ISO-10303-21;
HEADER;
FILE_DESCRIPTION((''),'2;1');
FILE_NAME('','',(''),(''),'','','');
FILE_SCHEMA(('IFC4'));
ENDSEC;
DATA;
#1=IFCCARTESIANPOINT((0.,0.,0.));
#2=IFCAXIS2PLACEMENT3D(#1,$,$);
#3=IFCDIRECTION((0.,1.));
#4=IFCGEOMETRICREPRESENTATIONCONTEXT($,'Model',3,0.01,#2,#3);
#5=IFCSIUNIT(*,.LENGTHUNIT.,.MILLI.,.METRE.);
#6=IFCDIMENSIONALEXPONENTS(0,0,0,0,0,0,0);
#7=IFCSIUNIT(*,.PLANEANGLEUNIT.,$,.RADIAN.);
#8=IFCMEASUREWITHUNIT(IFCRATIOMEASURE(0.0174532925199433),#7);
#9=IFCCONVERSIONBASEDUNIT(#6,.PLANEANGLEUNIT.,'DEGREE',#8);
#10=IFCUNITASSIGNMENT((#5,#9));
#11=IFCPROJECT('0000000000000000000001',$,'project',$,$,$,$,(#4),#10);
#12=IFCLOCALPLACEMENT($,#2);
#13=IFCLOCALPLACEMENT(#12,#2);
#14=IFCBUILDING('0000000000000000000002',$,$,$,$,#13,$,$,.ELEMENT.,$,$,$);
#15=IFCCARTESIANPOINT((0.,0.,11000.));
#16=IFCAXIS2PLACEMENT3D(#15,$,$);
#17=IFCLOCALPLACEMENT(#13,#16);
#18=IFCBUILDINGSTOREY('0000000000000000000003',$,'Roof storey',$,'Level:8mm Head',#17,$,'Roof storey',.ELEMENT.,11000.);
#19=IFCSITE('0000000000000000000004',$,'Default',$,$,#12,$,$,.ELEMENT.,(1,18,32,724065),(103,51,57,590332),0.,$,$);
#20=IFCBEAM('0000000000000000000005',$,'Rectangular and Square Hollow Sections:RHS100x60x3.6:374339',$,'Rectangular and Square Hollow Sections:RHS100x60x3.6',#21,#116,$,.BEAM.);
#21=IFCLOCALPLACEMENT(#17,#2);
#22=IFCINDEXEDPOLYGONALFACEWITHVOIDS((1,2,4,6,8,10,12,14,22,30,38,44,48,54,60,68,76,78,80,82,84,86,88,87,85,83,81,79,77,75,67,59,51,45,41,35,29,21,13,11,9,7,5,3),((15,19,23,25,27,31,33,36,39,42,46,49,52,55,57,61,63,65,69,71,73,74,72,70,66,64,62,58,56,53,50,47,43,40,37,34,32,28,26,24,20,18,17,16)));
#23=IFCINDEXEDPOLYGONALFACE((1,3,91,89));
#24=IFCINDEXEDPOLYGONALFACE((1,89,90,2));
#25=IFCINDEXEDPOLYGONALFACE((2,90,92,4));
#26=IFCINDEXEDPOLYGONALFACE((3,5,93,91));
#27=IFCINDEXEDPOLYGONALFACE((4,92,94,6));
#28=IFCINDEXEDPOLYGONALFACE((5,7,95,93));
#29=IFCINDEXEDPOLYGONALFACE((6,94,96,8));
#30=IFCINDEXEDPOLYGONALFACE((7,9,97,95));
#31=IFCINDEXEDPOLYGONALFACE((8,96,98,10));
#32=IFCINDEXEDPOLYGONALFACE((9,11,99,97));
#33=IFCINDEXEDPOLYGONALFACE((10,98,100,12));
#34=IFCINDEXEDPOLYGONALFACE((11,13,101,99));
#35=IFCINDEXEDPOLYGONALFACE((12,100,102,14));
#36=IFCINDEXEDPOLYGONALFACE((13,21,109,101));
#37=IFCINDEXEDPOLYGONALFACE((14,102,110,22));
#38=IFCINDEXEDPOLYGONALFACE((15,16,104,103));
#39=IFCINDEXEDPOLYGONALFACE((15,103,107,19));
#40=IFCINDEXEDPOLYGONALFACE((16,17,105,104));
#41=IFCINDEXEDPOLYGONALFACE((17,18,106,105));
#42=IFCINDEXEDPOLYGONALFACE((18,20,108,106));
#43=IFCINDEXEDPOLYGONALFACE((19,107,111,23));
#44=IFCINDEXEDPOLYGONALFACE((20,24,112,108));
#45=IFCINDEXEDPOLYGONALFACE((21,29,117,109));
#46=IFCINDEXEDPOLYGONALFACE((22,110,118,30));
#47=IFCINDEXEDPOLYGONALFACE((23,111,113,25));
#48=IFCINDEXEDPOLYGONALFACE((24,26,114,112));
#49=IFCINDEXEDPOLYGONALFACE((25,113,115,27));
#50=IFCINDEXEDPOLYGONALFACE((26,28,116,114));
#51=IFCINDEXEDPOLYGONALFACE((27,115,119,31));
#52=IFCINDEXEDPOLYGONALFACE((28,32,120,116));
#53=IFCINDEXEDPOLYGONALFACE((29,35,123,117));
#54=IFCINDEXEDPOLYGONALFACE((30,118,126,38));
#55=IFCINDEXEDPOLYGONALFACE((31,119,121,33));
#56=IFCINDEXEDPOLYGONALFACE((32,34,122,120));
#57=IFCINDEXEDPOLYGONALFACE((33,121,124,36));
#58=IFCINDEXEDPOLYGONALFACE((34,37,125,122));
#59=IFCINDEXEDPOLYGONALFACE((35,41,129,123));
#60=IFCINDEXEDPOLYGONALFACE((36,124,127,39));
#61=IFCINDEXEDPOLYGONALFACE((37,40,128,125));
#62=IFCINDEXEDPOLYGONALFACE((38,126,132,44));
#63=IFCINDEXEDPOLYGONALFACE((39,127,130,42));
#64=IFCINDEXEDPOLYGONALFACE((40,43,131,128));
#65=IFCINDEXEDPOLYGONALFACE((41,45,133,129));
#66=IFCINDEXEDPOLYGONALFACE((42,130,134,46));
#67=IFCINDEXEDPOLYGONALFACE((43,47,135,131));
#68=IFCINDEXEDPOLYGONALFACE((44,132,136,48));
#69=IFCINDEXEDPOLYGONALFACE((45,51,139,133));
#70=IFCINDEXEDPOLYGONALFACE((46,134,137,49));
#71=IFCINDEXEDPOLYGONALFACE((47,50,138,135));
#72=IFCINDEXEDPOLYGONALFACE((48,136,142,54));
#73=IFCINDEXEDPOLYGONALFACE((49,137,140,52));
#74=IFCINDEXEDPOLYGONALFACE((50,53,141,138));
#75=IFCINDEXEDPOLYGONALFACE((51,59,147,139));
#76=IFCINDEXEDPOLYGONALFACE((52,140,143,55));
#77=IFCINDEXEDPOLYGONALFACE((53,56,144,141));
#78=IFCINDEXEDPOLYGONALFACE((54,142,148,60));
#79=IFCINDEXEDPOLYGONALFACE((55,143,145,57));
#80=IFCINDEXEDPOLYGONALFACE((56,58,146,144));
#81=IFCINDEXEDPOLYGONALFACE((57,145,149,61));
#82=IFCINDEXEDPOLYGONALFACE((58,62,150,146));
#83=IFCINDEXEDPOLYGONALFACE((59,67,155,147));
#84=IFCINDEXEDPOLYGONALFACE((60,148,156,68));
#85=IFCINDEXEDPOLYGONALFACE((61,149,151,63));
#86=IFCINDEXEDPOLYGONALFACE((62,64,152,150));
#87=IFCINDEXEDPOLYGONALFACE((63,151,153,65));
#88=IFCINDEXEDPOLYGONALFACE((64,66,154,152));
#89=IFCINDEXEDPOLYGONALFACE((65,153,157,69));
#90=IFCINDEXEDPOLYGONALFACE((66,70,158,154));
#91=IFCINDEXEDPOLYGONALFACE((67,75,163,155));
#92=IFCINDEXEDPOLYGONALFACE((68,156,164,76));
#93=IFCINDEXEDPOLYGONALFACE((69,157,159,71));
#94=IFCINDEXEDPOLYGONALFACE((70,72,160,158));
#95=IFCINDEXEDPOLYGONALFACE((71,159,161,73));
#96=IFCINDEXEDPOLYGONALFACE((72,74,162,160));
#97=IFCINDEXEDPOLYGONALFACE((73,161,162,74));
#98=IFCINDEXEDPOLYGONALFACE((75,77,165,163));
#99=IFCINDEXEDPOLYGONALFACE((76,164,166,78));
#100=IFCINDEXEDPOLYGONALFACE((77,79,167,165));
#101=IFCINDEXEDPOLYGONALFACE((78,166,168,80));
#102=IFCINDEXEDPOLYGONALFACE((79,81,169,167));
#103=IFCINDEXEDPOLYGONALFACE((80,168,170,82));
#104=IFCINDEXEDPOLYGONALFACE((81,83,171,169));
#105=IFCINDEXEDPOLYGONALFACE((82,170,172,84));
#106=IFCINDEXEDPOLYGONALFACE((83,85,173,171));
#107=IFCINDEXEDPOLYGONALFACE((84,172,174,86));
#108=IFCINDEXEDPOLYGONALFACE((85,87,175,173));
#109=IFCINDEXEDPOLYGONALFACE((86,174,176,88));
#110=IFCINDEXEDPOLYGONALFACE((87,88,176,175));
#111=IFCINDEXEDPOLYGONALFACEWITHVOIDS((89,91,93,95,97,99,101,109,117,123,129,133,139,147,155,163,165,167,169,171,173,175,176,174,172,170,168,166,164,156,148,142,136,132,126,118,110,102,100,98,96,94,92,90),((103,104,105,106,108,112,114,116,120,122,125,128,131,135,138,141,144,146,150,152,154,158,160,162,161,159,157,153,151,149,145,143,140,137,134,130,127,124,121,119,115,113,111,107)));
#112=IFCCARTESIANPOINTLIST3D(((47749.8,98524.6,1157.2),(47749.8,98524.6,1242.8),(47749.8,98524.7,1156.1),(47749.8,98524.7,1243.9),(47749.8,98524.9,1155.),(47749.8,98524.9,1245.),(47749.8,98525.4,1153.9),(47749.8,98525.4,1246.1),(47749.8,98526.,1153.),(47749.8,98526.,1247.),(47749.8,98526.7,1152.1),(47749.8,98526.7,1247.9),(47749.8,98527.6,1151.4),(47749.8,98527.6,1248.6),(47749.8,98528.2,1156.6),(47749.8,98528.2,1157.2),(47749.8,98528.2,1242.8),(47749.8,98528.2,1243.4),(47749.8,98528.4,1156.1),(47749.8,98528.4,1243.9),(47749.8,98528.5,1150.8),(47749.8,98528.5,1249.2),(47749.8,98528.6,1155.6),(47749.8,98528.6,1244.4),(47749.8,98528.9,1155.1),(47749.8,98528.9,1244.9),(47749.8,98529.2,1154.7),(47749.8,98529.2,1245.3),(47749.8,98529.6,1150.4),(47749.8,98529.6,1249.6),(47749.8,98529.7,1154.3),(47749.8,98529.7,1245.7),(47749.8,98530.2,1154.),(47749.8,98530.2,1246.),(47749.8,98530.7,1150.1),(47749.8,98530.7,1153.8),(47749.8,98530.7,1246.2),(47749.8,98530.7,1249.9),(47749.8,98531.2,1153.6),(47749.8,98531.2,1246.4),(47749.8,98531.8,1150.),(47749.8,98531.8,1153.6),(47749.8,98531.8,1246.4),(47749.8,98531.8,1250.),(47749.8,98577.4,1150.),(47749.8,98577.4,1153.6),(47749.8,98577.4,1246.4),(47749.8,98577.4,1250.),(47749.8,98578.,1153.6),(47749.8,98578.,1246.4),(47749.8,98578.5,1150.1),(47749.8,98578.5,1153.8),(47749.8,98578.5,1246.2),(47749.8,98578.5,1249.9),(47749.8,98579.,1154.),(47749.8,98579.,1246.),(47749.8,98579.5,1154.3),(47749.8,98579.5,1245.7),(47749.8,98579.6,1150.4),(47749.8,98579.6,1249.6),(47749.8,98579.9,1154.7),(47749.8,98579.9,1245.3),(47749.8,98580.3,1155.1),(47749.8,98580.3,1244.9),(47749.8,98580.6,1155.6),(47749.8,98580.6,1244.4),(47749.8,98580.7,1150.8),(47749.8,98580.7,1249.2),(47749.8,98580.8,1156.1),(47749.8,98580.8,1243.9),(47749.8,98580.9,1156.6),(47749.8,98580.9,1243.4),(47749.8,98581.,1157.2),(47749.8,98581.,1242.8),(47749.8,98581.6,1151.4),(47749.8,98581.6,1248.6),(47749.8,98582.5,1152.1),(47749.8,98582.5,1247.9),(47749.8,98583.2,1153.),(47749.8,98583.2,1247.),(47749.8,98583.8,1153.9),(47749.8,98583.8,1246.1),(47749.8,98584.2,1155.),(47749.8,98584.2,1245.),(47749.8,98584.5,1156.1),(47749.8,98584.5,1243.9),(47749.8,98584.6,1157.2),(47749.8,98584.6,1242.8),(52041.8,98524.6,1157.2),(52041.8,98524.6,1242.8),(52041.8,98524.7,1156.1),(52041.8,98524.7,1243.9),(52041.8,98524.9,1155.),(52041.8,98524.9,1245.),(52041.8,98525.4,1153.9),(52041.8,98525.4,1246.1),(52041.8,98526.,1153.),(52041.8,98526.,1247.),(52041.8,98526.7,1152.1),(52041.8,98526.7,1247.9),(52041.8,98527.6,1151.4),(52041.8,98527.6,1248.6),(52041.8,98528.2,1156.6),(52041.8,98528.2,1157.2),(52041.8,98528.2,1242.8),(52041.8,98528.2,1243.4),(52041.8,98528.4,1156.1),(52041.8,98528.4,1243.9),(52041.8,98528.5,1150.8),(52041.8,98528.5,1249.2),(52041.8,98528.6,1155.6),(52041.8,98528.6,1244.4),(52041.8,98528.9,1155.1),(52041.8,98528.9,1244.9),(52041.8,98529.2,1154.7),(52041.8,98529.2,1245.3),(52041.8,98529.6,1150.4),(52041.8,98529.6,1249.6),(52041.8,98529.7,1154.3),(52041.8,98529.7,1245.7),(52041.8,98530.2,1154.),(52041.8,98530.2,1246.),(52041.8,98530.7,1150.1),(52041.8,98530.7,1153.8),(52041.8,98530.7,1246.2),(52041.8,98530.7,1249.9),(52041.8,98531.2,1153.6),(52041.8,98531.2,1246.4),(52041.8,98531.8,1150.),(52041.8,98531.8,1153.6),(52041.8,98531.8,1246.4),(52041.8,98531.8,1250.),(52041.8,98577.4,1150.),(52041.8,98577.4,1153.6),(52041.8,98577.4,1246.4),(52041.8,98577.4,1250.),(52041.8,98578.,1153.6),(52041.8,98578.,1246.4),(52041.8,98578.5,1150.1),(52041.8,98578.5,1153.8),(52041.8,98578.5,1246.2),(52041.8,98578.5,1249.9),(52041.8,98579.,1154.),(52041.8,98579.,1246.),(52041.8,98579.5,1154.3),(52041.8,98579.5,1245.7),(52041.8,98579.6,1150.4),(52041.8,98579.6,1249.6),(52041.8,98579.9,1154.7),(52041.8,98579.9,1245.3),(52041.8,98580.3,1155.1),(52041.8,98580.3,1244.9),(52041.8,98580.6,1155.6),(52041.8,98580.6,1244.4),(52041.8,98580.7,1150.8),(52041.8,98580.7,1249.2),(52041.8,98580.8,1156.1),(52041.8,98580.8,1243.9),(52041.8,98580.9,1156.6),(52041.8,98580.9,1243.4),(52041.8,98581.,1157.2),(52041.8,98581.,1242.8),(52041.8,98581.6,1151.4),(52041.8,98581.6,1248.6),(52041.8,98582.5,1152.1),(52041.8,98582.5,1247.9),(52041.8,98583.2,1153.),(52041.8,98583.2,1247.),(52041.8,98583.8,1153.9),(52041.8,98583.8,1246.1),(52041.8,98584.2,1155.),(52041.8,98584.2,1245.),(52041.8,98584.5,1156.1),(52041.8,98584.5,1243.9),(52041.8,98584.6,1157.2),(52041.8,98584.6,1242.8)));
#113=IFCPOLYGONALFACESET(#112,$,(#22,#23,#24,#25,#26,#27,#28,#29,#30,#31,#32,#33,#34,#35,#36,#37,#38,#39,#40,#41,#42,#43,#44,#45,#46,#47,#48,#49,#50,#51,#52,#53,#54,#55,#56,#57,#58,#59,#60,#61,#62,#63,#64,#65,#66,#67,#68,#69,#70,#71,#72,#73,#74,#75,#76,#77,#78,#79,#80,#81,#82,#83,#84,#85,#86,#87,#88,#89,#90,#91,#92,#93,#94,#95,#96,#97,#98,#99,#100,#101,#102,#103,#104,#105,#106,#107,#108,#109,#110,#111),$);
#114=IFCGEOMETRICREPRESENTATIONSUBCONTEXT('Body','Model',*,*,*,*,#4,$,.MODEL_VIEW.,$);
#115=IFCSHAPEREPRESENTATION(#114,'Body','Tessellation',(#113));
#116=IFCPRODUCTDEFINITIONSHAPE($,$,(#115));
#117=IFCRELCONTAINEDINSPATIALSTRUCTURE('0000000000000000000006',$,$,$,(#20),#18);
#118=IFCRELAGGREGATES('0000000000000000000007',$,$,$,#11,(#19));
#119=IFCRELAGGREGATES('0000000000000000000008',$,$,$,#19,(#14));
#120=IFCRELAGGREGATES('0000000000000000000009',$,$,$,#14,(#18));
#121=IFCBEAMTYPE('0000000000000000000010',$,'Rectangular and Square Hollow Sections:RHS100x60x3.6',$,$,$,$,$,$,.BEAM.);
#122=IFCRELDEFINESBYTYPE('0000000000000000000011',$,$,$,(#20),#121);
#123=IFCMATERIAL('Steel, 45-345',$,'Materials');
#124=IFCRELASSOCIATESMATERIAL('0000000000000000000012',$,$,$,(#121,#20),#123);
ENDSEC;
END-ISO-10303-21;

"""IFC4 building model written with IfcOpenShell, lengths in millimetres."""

from ifc_helpers import new_model, entity, si_unit, converted_unit, direction, frame, origin, place, context, subcontext, project, spatial, indexed_curve, outline, extrude, source, transform, mapped, material, type_object, type_shapes, element, save


model = new_model("IFC4")

# Units and contexts
model_context = context("Model", 3, precision=0.01, world=origin(), true_north=direction((0.0, 1.0)))
body_context = subcontext(model_context, "Body", "Model", "MODEL_VIEW")
ifc_project = project(units=[si_unit("LENGTHUNIT", "METRE", prefix="MILLI"), converted_unit("PLANEANGLEUNIT", "DEGREE", entity("IfcRatioMeasure", 0.0174532925199433), si_unit("PLANEANGLEUNIT", "RADIAN"), dimensions=[0, 0, 0, 0, 0, 0, 0])], contexts=[model_context])

# Site, building, storey
site_placement = place(None, origin())
site = spatial("IfcSite", under=ifc_project, at=site_placement, Name="Default", CompositionType="ELEMENT", RefLatitude=(1, 18, 32, 724065), RefLongitude=(103, 51, 57, 590332), RefElevation=0.0)
building_placement = place(site_placement, origin())
building = spatial("IfcBuilding", under=site, at=building_placement, CompositionType="ELEMENT")
storey_placement = place(building_placement, frame((0.0, 0.0, 11000.0)))
storey = spatial("IfcBuildingStorey", under=building, at=storey_placement, Name="Roof storey", ObjectType="Level:8mm Head", LongName="Roof storey", CompositionType="ELEMENT", Elevation=11000.0)

# Shared definitions
ifc_material = material(Name="Steel, 45-345", Category="Materials")

# Beam
beam_type_1 = type_object("IfcBeamType", Name="Rectangular and Square Hollow Sections:RHS100x60x3.6", PredefinedType="BEAM", material=ifc_material)
shared_shape_1 = source(origin(), body_context, "Body", "SweptSolid", [
    extrude(outline(indexed_curve([(-30.0, -42.8), (-29.9, -43.9), (-29.6, -45.0), (-29.2, -46.1), (-28.6, -47.0), (-27.9, -47.9), (-27.0, -48.6), (-26.1, -49.2), (-25.0, -49.6), (-23.9, -49.9), (-22.8, -50.0), (22.8, -50.0), (23.9, -49.9), (25.0, -49.6), (26.1, -49.2), (27.0, -48.6), (27.9, -47.9), (28.6, -47.0), (29.2, -46.1), (29.6, -45.0), (29.9, -43.9), (30.0, -42.8), (30.0, 42.8), (29.9, 43.9), (29.6, 45.0), (29.2, 46.1), (28.6, 47.0), (27.9, 47.9), (27.0, 48.6), (26.1, 49.2), (25.0, 49.6), (23.9, 49.9), (22.8, 50.0), (-22.8, 50.0), (-23.9, 49.9), (-25.0, 49.6), (-26.1, 49.2), (-27.0, 48.6), (-27.9, 47.9), (-28.6, 47.0), (-29.2, 46.1), (-29.6, 45.0), (-29.9, 43.9), (-30.0, 42.8), (-30.0, -42.8)], self_intersect=False), holes=[indexed_curve([(22.8, -46.4), (-22.8, -46.4), (-23.4, -46.4), (-23.9, -46.2), (-24.4, -46.0), (-24.9, -45.7), (-25.3, -45.3), (-25.7, -44.9), (-26.0, -44.4), (-26.2, -43.9), (-26.4, -43.4), (-26.4, -42.8), (-26.4, 42.8), (-26.4, 43.4), (-26.2, 43.9), (-26.0, 44.4), (-25.7, 44.9), (-25.3, 45.3), (-24.9, 45.7), (-24.4, 46.0), (-23.9, 46.2), (-23.4, 46.4), (-22.8, 46.4), (22.8, 46.4), (23.4, 46.4), (23.9, 46.2), (24.4, 46.0), (24.9, 45.7), (25.3, 45.3), (25.7, 44.9), (26.0, 44.4), (26.2, 43.9), (26.4, 43.4), (26.4, 42.8), (26.4, -42.8), (26.4, -43.4), (26.2, -43.9), (26.0, -44.4), (25.7, -44.9), (25.3, -45.3), (24.9, -45.7), (24.4, -46.0), (23.9, -46.2), (23.4, -46.4), (22.8, -46.4)], self_intersect=False)]), frame((-2139.5, 0.0, 0.0), z_axis=(1.0, 0.0, 0.0), x_axis=(0.0, -1.0, 0.0)), (0.0, 0.0, 1.0), 4292.0),
])
type_shapes(beam_type_1, [shared_shape_1])
for number, where, name in (
    (1, (49889.3, 98554.6, 1200.0), "Rectangular and Square Hollow Sections:RHS100x60x3.6:374339"),
):
    element("IfcBeam", number, at=place(storey_placement, frame(where)), inside=storey, type_object=beam_type_1, material=ifc_material, Name=name, ObjectType="Rectangular and Square Hollow Sections:RHS100x60x3.6", PredefinedType="BEAM", context=body_context, shape_type="MappedRepresentation", body=[
        mapped(shared_shape_1, transform((0.0, 0.0, 0.0), scale=1.0)),
    ])

save(model, "model.ifc")
